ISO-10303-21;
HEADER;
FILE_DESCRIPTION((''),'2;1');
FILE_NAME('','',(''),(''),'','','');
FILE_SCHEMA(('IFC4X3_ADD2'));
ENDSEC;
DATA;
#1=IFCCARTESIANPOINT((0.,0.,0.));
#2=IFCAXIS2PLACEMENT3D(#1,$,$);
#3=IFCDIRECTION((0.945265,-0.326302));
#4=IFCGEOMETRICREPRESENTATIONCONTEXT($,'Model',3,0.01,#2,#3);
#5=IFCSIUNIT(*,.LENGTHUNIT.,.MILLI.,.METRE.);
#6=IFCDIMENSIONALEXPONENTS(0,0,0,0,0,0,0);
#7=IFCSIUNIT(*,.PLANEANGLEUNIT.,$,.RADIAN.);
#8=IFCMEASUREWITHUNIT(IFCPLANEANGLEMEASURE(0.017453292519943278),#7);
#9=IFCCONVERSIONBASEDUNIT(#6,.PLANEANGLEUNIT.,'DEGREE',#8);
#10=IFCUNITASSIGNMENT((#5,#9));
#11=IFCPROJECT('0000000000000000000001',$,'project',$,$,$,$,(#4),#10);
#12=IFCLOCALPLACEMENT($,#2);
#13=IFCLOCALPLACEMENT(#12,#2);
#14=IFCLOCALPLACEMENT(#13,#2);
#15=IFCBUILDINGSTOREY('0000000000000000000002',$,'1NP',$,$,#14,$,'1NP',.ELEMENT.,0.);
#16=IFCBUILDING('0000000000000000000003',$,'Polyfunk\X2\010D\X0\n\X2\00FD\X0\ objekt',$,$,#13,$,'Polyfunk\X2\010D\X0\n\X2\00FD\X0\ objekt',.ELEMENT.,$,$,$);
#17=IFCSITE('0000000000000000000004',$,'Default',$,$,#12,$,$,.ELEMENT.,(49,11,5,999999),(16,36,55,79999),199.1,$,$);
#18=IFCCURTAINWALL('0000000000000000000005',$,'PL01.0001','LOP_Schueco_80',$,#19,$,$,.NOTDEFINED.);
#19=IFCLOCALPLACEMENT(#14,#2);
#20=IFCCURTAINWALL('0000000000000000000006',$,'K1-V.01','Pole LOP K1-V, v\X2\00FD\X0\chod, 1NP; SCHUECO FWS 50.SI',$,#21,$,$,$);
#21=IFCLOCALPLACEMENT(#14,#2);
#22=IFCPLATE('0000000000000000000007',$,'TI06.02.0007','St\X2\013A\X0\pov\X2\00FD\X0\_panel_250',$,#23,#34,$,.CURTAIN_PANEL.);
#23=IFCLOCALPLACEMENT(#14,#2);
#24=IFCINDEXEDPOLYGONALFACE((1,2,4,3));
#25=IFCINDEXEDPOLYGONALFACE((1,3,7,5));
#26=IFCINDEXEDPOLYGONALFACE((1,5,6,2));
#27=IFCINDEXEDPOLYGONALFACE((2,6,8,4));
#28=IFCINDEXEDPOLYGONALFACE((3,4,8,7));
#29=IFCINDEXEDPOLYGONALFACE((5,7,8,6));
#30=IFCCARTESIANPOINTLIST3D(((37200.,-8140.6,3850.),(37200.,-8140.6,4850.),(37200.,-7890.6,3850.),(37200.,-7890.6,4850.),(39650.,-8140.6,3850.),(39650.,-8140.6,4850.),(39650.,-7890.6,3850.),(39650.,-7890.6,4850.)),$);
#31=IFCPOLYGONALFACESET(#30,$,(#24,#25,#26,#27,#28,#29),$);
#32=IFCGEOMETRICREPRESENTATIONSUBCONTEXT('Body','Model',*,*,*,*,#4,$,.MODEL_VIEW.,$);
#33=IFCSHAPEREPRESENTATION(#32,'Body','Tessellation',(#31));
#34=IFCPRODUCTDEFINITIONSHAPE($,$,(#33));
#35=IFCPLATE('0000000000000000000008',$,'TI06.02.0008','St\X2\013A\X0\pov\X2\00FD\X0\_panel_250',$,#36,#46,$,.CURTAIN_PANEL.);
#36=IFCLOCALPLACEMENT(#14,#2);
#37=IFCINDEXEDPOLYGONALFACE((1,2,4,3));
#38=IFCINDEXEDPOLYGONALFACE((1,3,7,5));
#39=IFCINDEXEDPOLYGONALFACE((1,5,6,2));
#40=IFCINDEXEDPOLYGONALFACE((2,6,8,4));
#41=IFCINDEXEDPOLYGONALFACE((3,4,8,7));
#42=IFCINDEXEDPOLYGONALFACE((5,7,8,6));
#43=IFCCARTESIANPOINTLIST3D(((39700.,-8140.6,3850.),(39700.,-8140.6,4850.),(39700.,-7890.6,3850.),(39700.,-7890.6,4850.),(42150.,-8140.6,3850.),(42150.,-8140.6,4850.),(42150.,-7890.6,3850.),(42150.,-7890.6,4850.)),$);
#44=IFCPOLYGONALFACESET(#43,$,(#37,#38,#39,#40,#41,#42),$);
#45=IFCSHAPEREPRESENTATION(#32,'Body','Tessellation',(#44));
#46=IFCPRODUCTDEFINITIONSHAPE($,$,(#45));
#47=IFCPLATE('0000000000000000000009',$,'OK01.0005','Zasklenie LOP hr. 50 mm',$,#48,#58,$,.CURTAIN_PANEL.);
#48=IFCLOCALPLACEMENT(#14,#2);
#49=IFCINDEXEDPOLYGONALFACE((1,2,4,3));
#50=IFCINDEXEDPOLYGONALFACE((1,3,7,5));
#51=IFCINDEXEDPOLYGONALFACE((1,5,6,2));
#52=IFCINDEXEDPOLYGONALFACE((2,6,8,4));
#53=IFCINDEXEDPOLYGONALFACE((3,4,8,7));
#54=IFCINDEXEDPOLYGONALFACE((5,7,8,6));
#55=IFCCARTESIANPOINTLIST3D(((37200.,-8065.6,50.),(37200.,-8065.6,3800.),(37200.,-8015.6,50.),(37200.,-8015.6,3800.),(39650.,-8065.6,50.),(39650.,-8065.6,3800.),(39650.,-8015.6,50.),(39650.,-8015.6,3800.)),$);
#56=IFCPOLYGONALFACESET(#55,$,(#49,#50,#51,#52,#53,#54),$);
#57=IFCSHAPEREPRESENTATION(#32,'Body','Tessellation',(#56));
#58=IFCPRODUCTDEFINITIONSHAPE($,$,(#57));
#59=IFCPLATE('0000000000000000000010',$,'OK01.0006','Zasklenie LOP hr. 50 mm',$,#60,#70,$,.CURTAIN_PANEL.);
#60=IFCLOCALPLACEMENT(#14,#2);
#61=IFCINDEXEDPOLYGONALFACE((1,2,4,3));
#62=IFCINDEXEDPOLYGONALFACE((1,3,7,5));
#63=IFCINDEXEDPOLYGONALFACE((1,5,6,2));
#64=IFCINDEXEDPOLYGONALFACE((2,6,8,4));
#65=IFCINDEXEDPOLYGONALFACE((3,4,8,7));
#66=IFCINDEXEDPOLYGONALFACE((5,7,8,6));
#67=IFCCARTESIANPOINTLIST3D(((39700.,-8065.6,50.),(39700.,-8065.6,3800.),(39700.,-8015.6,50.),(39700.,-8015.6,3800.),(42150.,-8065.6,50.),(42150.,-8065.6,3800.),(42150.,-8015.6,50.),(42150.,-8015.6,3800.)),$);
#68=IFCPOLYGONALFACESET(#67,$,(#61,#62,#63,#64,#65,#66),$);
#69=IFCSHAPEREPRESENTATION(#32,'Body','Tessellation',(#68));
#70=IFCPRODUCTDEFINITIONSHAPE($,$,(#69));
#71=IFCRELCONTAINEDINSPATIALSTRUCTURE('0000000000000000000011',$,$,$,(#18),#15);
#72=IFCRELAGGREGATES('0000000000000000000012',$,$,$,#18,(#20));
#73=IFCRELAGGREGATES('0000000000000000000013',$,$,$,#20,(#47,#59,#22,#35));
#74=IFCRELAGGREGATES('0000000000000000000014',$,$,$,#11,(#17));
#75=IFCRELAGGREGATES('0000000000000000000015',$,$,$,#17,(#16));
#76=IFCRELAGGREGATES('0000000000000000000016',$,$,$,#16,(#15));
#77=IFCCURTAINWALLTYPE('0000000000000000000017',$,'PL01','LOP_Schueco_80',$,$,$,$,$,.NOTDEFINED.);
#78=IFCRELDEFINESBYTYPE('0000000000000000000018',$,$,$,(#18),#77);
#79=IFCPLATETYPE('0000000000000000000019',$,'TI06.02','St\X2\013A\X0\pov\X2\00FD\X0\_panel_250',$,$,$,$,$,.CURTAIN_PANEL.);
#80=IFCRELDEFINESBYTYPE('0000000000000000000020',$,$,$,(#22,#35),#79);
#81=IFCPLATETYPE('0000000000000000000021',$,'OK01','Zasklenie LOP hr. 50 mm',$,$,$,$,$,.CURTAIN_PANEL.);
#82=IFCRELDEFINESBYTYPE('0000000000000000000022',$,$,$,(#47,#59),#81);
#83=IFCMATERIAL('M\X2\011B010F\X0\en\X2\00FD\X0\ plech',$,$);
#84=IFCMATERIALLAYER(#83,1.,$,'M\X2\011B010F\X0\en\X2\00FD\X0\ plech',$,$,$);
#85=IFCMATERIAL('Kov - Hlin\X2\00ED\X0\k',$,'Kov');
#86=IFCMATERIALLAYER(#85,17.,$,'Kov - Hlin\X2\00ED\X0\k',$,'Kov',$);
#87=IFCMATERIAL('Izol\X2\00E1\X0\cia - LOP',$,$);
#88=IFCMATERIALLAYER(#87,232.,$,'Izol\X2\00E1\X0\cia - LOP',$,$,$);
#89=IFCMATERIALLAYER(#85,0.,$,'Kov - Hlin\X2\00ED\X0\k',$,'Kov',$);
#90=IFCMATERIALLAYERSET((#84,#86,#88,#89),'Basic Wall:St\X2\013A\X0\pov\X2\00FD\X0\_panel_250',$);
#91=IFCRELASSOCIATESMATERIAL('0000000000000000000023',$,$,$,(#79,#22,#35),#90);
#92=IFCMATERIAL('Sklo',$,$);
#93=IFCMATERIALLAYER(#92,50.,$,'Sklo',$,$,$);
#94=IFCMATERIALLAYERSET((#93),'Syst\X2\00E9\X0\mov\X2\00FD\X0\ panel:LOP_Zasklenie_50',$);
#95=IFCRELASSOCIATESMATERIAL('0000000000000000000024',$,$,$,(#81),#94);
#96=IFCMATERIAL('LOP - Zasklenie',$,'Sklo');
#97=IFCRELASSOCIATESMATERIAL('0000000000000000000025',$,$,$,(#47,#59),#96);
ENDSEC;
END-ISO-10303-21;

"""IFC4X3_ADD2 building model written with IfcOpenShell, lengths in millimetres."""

from ifc_helpers import new_model, entity, si_unit, converted_unit, direction, frame, frame_2d, origin, place, context, subcontext, project, spatial, rectangle, extrude, source, transform, mapped, material, layer, layer_set, layer_usage, type_object, type_shapes, element, aggregate, save


model = new_model("IFC4X3_ADD2")

# Units and contexts
model_context = context("Model", 3, precision=0.01, world=origin(), true_north=direction((0.945265, -0.326302)))
body_context = subcontext(model_context, "Body", "Model", "MODEL_VIEW")
ifc_project = project(units=[si_unit("LENGTHUNIT", "METRE", prefix="MILLI"), converted_unit("PLANEANGLEUNIT", "DEGREE", entity("IfcPlaneAngleMeasure", 0.017453292519943278), si_unit("PLANEANGLEUNIT", "RADIAN"), dimensions=[0, 0, 0, 0, 0, 0, 0])], contexts=[model_context])

# Site, building, storey
site_placement = place(None, origin())
site = spatial("IfcSite", under=ifc_project, at=site_placement, Name="Default", CompositionType="ELEMENT", RefLatitude=(49, 11, 5, 999999), RefLongitude=(16, 36, 55, 79999), RefElevation=199.1)
building_placement = place(site_placement, origin())
building = spatial("IfcBuilding", under=site, at=building_placement, Name="Polyfunkčný objekt", LongName="Polyfunkčný objekt", CompositionType="ELEMENT")
storey_placement = place(building_placement, origin())
storey = spatial("IfcBuildingStorey", under=building, at=storey_placement, Name="1NP", LongName="1NP", CompositionType="ELEMENT", Elevation=0.0)

# Curtain walls, plates
curtain_wall_type = type_object("IfcCurtainWallType", Name="PL01", Description="LOP_Schueco_80", PredefinedType="NOTDEFINED")
curtain_wall_1_placement = place(storey_placement, origin())
curtain_wall_1 = element("IfcCurtainWall", 1, at=curtain_wall_1_placement, inside=storey, type_object=curtain_wall_type, Name="PL01.0001", Description="LOP_Schueco_80", PredefinedType="NOTDEFINED")
curtain_wall_2 = element("IfcCurtainWall", 2, Name="K1-V.01", Description="Pole LOP K1-V, východ, 1NP; SCHUECO FWS 50.SI")
aggregate(curtain_wall_1, [curtain_wall_2])
ifc_material_1 = material(Name="Měďený plech")
ifc_layer_1 = layer(ifc_material_1, 1.0, Name="Měďený plech")
ifc_material_2 = material(Name="Kov - Hliník", Category="Kov")
ifc_layer_2 = layer(ifc_material_2, 17.0, Name="Kov - Hliník", Category="Kov")
ifc_material_3 = material(Name="Izolácia - LOP")
ifc_layer_3 = layer(ifc_material_3, 232.0, Name="Izolácia - LOP")
ifc_layer_4 = layer(ifc_material_2, 0.0, Name="Kov - Hliník", Category="Kov")
ifc_layer_set_1 = layer_set([ifc_layer_1, ifc_layer_2, ifc_layer_3, ifc_layer_4], Name="Basic Wall:Stĺpový_panel_250")
ifc_layer_usage_1 = layer_usage(ifc_layer_set_1, "AXIS2", "POSITIVE", -125.0)
plate_type_1 = type_object("IfcPlateType", Name="TI06.02", Description="Stĺpový_panel_250", PredefinedType="CURTAIN_PANEL", material=ifc_layer_set_1)
plate_1_placement = place(storey_placement, frame((37200.0, -8015.6, 3850.0)))
plate_1 = element("IfcPlate", 3, at=plate_1_placement, type_object=plate_type_1, material=ifc_layer_usage_1, Name="TI06.02.0007", Description="Stĺpový_panel_250", PredefinedType="CURTAIN_PANEL", context=body_context, shape_type="SweptSolid", body=[
    extrude(rectangle(XDim=250.0, YDim=2450.0, at=frame_2d((0.0, 0.0), x_axis=(1.0, 0.0))), frame((1225.0, 0.0, 0.0), z_axis=(0.0, 0.0, 1.0), x_axis=(0.0, 1.0, 0.0)), (0.0, 0.0, 1.0), 1000.0),
])
ifc_layer_usage_2 = layer_usage(ifc_layer_set_1, "AXIS2", "POSITIVE", -125.0)
plate_2_placement = place(storey_placement, frame((39700.0, -8015.6, 3850.0)))
plate_2 = element("IfcPlate", 4, at=plate_2_placement, type_object=plate_type_1, material=ifc_layer_usage_2, Name="TI06.02.0008", Description="Stĺpový_panel_250", PredefinedType="CURTAIN_PANEL", context=body_context, shape_type="SweptSolid", body=[
    extrude(rectangle(XDim=250.0, YDim=2450.0, at=frame_2d((0.0, 0.0), x_axis=(1.0, 0.0))), frame((1225.0, 0.0, 0.0), z_axis=(0.0, 0.0, 1.0), x_axis=(0.0, 1.0, 0.0)), (0.0, 0.0, 1.0), 1000.0),
])
ifc_material_4 = material(Name="LOP - Zasklenie", Category="Sklo")
ifc_material_5 = material(Name="Sklo")
ifc_layer_5 = layer(ifc_material_5, 50.0, Name="Sklo")
ifc_layer_set_2 = layer_set([ifc_layer_5], Name="Systémový panel:LOP_Zasklenie_50")
plate_type_2 = type_object("IfcPlateType", Name="OK01", Description="Zasklenie LOP hr. 50 mm", PredefinedType="CURTAIN_PANEL", material=ifc_layer_set_2)
shared_shape_1 = source(origin(), body_context, "Body", "SweptSolid", [
    extrude(rectangle(XDim=3750.0, YDim=2450.0, at=frame_2d((-331.2, 0.0), x_axis=(1.0, 0.0))), frame((0.0, -50.0, 2206.2), z_axis=(0.0, 1.0, 0.0), x_axis=(0.0, 0.0, 1.0)), (0.0, 0.0, 1.0), 50.0),
])
type_shapes(plate_type_2, [shared_shape_1])
plate_3_placement = place(curtain_wall_1_placement, frame((38425.0, -8015.6, 50.0)))
plate_3 = element("IfcPlate", 5, at=plate_3_placement, type_object=plate_type_2, material=ifc_material_4, Name="OK01.0005", Description="Zasklenie LOP hr. 50 mm", PredefinedType="CURTAIN_PANEL", context=body_context, shape_type="MappedRepresentation", body=[
    mapped(shared_shape_1, transform((0.0, 0.0, 0.0), scale=1.0)),
])
plate_4_placement = place(curtain_wall_1_placement, frame((40925.0, -8015.6, 50.0)))
plate_4 = element("IfcPlate", 6, at=plate_4_placement, type_object=plate_type_2, material=ifc_material_4, Name="OK01.0006", Description="Zasklenie LOP hr. 50 mm", PredefinedType="CURTAIN_PANEL", context=body_context, shape_type="MappedRepresentation", body=[
    mapped(shared_shape_1, transform((0.0, 0.0, 0.0), scale=1.0)),
])
aggregate(curtain_wall_2, [plate_3, plate_4, plate_1, plate_2])

save(model, "model.ifc")
